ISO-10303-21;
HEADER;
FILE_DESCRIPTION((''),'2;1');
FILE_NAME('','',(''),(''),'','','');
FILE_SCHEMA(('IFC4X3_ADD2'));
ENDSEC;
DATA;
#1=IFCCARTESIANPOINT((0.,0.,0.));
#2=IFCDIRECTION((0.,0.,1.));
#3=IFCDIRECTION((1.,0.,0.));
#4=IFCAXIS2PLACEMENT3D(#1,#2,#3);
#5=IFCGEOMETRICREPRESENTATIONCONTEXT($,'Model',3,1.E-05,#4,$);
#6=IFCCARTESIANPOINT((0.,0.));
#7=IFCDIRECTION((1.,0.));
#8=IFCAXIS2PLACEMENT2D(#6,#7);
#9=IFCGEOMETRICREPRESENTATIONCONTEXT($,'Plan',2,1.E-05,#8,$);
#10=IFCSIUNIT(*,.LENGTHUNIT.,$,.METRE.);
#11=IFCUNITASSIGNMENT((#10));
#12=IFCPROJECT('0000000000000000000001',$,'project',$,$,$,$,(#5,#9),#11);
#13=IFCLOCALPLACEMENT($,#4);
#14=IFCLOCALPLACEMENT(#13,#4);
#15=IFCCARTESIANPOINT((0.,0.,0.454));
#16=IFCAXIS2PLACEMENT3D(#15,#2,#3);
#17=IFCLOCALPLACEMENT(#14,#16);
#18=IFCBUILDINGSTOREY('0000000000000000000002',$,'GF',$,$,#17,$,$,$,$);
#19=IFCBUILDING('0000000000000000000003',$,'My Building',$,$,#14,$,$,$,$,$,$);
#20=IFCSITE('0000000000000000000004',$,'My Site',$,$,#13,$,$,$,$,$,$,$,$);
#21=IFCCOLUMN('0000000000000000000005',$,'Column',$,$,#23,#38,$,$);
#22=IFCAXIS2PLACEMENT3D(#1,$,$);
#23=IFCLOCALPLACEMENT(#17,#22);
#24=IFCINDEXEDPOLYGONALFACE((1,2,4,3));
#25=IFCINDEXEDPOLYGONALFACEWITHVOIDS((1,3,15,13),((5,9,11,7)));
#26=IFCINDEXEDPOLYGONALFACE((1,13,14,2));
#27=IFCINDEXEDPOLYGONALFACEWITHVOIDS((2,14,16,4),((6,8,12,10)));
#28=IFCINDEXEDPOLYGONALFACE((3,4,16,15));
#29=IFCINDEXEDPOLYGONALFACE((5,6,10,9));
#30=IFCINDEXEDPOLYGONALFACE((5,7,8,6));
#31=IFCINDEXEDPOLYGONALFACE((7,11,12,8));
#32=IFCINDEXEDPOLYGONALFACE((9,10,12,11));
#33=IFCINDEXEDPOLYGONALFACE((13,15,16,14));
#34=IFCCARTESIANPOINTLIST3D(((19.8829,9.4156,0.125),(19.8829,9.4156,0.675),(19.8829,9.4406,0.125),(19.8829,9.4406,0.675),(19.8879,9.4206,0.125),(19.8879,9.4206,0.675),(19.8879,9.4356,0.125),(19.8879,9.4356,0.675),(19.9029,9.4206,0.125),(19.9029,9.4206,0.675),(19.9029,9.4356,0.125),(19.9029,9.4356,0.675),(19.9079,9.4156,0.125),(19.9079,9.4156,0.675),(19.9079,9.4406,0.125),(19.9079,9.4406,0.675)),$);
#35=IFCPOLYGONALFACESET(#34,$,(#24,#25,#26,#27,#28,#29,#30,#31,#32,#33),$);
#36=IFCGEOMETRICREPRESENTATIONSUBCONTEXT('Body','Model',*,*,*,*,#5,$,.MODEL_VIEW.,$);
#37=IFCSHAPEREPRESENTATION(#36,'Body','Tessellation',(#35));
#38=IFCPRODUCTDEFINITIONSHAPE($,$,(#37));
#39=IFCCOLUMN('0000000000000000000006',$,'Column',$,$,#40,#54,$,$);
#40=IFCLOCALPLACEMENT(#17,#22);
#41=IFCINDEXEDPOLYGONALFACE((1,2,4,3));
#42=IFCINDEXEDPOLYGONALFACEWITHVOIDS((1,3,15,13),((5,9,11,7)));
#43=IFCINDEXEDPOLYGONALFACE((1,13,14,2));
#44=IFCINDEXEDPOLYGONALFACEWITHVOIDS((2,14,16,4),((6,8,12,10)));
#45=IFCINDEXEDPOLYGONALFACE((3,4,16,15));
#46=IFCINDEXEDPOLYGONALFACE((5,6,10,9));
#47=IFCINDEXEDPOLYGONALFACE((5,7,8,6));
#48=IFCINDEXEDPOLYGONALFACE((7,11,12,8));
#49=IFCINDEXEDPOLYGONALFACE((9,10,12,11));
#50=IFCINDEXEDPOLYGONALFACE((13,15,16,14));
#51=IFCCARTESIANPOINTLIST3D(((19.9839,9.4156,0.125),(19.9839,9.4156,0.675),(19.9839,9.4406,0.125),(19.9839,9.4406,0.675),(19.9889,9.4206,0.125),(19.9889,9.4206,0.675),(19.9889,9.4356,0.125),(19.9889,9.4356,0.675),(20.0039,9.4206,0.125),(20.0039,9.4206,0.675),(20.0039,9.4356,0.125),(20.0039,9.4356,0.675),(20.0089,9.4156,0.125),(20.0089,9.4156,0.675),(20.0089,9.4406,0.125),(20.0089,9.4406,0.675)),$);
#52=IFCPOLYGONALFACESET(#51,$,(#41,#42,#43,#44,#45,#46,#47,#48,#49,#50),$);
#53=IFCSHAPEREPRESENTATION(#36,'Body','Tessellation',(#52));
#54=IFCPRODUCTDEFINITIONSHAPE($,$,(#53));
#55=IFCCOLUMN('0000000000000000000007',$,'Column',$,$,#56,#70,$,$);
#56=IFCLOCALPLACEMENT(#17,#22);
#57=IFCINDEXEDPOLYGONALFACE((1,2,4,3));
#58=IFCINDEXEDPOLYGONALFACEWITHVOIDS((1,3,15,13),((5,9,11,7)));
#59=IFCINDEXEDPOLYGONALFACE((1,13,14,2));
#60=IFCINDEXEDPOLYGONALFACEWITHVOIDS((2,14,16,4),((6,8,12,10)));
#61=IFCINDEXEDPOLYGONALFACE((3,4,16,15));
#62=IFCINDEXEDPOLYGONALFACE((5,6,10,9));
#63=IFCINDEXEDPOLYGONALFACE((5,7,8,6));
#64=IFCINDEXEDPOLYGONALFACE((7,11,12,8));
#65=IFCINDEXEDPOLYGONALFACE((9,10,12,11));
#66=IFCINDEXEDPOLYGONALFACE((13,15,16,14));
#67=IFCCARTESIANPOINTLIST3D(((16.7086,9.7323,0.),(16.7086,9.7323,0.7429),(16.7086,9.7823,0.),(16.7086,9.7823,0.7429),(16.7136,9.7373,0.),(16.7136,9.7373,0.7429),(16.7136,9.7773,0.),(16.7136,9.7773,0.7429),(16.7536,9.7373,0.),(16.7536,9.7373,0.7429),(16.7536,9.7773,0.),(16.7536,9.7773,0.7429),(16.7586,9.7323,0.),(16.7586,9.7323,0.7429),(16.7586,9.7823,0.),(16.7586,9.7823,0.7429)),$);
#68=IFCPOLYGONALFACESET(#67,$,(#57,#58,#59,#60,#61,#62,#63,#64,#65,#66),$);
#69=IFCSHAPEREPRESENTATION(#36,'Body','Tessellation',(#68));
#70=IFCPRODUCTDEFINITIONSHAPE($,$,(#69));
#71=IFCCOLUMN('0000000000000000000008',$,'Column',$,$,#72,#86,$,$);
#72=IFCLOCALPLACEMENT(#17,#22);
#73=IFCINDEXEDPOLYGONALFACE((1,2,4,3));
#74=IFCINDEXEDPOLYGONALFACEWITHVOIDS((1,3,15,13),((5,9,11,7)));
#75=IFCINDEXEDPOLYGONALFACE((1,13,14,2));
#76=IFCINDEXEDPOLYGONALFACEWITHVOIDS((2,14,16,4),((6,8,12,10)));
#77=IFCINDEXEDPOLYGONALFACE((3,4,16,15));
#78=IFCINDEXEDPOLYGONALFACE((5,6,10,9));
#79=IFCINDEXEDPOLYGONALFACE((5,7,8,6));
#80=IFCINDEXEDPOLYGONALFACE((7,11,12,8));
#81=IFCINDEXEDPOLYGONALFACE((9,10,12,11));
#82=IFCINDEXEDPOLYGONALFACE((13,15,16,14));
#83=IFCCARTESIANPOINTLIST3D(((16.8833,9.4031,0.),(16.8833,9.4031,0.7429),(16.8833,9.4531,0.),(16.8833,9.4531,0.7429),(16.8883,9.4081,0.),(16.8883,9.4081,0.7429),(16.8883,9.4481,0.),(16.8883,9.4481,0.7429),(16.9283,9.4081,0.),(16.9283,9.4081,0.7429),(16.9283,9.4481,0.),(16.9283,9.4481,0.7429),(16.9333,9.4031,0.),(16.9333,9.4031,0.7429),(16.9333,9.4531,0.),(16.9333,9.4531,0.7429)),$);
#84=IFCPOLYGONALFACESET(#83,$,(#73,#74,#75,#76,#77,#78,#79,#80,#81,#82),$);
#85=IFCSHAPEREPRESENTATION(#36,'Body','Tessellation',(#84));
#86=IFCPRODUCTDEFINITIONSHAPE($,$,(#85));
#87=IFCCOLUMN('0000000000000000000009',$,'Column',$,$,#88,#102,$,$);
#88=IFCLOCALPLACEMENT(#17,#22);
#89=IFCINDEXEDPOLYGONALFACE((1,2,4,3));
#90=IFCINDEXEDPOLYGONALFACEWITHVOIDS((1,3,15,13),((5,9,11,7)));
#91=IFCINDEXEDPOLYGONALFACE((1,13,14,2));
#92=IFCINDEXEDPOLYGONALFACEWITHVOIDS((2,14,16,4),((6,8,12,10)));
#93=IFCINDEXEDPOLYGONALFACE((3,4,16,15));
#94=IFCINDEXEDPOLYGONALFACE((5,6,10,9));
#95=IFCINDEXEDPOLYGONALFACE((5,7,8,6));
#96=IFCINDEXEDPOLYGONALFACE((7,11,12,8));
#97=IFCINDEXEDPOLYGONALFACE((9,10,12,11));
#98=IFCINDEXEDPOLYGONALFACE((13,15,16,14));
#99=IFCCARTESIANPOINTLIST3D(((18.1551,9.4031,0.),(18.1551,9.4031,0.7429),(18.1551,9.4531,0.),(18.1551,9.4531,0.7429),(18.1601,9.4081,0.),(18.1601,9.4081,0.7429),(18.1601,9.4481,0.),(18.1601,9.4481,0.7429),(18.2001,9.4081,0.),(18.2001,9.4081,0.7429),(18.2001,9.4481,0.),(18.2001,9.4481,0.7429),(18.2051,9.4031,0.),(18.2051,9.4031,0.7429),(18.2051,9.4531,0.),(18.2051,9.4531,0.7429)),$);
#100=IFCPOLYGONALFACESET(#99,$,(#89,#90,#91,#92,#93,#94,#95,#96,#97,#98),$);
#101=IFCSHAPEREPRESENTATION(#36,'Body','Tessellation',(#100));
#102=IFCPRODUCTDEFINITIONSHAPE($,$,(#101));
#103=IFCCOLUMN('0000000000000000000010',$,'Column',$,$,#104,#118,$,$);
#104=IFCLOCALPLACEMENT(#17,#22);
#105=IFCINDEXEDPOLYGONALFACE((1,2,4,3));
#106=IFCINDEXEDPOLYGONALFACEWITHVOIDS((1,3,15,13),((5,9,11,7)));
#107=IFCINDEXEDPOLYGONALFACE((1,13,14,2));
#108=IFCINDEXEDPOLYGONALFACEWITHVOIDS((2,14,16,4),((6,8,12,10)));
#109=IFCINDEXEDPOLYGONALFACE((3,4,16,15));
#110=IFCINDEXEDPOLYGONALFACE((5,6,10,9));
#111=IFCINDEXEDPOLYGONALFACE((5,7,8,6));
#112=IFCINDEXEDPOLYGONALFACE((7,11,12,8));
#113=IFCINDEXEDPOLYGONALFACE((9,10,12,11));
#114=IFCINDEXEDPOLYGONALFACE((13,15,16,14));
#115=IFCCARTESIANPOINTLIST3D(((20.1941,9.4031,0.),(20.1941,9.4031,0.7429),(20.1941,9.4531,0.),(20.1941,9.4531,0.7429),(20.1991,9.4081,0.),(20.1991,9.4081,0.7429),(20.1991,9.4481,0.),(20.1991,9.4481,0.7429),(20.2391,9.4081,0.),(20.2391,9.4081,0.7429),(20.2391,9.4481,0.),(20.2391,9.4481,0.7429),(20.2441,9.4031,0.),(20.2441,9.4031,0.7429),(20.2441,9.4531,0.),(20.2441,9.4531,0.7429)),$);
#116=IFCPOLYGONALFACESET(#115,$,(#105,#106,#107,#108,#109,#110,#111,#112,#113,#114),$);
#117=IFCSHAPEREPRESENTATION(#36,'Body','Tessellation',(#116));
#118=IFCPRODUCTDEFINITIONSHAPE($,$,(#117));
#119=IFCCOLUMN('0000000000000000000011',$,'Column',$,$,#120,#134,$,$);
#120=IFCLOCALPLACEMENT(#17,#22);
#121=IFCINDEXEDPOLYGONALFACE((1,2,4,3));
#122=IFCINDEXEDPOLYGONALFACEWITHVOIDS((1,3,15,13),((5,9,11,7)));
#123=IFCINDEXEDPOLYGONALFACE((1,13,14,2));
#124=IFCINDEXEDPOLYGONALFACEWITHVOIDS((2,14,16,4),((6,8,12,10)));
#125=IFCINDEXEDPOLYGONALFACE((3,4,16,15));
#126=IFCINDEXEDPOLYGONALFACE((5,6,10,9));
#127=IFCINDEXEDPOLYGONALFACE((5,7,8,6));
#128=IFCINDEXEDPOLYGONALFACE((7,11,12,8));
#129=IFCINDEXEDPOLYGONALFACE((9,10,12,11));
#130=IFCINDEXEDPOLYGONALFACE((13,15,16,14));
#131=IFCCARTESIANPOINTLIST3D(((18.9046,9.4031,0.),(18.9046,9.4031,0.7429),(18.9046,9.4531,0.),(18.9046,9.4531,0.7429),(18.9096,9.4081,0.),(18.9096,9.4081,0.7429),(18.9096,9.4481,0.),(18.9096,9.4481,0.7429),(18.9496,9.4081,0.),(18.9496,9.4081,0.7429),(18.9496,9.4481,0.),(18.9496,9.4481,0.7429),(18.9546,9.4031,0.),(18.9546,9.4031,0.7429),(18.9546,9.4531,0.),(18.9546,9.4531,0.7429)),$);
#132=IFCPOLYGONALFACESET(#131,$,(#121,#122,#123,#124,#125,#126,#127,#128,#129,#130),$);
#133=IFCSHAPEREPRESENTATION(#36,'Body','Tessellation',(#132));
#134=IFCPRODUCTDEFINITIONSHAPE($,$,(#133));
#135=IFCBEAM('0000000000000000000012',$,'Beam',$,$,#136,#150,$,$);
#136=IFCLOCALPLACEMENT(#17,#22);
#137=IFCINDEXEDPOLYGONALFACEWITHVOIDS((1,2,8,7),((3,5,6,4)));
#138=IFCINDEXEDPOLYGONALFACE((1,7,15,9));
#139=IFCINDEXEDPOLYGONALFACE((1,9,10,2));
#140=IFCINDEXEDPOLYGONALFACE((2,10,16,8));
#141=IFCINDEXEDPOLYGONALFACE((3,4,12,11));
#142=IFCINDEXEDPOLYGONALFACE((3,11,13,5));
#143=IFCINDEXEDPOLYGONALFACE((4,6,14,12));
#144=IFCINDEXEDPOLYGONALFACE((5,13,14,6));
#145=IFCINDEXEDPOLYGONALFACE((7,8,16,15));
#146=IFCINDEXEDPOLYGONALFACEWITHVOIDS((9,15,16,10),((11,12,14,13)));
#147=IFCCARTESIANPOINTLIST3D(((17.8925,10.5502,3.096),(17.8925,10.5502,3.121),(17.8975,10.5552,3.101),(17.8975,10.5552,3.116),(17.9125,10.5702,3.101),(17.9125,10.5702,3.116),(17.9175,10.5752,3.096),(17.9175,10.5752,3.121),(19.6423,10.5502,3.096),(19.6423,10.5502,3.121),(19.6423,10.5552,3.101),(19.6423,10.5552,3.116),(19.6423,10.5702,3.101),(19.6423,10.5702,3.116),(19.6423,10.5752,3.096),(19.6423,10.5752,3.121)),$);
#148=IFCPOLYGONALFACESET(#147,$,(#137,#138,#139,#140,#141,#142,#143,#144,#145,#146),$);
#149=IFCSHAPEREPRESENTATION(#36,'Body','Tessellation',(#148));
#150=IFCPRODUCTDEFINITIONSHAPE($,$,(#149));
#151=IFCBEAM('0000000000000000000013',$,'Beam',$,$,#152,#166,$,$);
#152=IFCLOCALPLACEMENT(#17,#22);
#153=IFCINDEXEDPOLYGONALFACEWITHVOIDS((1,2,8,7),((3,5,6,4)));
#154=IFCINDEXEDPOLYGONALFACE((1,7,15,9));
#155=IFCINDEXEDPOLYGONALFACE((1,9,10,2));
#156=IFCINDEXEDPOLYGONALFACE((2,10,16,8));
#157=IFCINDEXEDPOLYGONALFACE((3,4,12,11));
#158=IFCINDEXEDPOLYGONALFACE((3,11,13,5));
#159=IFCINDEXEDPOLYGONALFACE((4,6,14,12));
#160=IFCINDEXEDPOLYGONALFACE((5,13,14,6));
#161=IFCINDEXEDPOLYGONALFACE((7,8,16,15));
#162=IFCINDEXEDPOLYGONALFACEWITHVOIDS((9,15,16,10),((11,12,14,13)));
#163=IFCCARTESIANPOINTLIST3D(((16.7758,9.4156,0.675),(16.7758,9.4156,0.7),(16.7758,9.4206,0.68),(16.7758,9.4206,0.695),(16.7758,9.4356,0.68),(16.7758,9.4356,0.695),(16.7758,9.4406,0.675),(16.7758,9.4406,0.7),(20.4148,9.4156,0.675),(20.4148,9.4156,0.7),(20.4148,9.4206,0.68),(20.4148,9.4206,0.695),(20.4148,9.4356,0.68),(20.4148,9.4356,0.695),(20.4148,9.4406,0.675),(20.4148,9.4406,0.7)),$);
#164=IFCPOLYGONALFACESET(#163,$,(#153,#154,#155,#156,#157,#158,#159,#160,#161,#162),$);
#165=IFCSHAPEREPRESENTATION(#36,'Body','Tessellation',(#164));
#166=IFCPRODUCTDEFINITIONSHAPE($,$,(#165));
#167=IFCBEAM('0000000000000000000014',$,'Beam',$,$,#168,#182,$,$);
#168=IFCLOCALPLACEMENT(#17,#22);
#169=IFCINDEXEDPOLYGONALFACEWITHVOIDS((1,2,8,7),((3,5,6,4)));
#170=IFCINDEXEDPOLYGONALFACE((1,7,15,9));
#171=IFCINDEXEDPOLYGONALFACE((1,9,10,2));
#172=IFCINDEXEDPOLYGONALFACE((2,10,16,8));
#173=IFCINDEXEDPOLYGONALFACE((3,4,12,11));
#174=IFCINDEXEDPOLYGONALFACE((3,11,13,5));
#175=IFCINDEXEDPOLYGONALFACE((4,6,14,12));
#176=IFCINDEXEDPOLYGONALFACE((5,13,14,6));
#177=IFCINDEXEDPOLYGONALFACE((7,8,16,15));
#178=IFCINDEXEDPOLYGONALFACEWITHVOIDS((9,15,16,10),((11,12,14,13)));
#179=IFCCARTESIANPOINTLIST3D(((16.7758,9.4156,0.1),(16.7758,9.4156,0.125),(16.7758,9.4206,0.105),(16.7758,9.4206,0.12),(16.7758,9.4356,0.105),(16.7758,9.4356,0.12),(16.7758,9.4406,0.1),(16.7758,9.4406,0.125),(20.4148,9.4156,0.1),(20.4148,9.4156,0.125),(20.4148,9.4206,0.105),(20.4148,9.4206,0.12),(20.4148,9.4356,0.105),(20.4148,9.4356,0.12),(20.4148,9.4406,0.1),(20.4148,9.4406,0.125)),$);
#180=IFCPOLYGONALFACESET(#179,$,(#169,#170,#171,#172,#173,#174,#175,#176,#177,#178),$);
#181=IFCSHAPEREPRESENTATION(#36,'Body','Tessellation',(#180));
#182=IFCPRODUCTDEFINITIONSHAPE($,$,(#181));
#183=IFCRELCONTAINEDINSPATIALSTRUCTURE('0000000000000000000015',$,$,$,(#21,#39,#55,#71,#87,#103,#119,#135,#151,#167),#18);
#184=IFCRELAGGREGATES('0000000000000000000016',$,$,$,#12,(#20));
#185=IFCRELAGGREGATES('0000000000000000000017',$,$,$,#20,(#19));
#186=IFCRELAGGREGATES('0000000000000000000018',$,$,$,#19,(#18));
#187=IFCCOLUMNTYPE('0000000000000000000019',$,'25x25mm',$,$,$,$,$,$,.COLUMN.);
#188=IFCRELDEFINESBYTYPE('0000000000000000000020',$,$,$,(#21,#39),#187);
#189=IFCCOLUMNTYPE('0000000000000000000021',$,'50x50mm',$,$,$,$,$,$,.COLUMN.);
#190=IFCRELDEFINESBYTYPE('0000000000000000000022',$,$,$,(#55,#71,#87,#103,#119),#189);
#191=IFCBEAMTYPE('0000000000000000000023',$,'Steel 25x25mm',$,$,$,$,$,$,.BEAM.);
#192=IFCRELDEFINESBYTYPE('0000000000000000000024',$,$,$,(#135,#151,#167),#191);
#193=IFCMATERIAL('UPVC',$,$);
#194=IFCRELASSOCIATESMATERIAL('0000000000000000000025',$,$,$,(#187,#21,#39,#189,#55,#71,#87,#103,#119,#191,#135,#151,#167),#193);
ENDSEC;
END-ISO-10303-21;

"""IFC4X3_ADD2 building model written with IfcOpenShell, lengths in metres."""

from ifc_helpers import new_model, si_unit, frame, origin_with_axes, origin_2d_with_axis, place, context, subcontext, project, spatial, hollow_rectangle, extrude, clip, halfspace, material, material_profile, profile_set, profile_usage, type_object, element, save


model = new_model("IFC4X3_ADD2")

# Units and contexts
model_context = context("Model", 3, precision=1e-05, world=origin_with_axes())
plan_context = context("Plan", 2, precision=1e-05, world=origin_2d_with_axis())
body_context = subcontext(model_context, "Body", "Model", "MODEL_VIEW")
ifc_project = project(units=[si_unit("LENGTHUNIT", "METRE")], contexts=[model_context, plan_context])

# Site, building, storey
site_placement = place(None, origin_with_axes())
site = spatial("IfcSite", under=ifc_project, at=site_placement, Name="My Site")
building_placement = place(site_placement, origin_with_axes())
building = spatial("IfcBuilding", under=site, at=building_placement, Name="My Building")
storey_placement = place(building_placement, frame((0.0, 0.0, 0.454), z_axis=(0.0, 0.0, 1.0), x_axis=(1.0, 0.0, 0.0)))
storey = spatial("IfcBuildingStorey", under=building, at=storey_placement, Name="GF")

# Columns
ifc_material_1 = material(Name="UPVC")
ifc_material_profile_1 = material_profile(ifc_material_1, hollow_rectangle(XDim=0.025, YDim=0.025, WallThickness=0.005))
ifc_profile_set_1 = profile_set([ifc_material_profile_1])
column_type_1 = type_object("IfcColumnType", Name="25x25mm", PredefinedType="COLUMN", material=ifc_profile_set_1)
ifc_profile_usage_1 = profile_usage(ifc_profile_set_1)
column_1_placement = place(storey_placement, frame((19.8954, 9.4281, 0.125), z_axis=(0.0, 0.0, 1.0), x_axis=(0.0, -1.0, 0.0)))
element("IfcColumn", 1, at=column_1_placement, inside=storey, type_object=column_type_1, material=ifc_profile_usage_1, Name="Column", context=body_context, shape_type="SweptSolid", body=[
    extrude(hollow_rectangle(XDim=0.025, YDim=0.025, WallThickness=0.005), origin_with_axes(), (0.0, 0.0, 1.0), 0.55),
])
ifc_profile_usage_2 = profile_usage(ifc_profile_set_1)
column_2_placement = place(storey_placement, frame((19.9964, 9.4281, 0.125), z_axis=(0.0, 0.0, 1.0), x_axis=(0.0, -1.0, 0.0)))
element("IfcColumn", 2, at=column_2_placement, inside=storey, type_object=column_type_1, material=ifc_profile_usage_2, Name="Column", context=body_context, shape_type="SweptSolid", body=[
    extrude(hollow_rectangle(XDim=0.025, YDim=0.025, WallThickness=0.005), origin_with_axes(), (0.0, 0.0, 1.0), 0.55),
])
ifc_material_profile_2 = material_profile(ifc_material_1, hollow_rectangle(XDim=0.05, YDim=0.05, WallThickness=0.005))
ifc_profile_set_2 = profile_set([ifc_material_profile_2])
ifc_profile_usage_3 = profile_usage(ifc_profile_set_2)
column_type_2 = type_object("IfcColumnType", Name="50x50mm", PredefinedType="COLUMN", material=ifc_profile_set_2)
column_3_placement = place(storey_placement, frame((16.7336, 9.7573, 0.0), z_axis=(0.0, 0.0, 1.0), x_axis=(0.0, -1.0, 0.0)))
element("IfcColumn", 3, at=column_3_placement, inside=storey, type_object=column_type_2, material=ifc_profile_usage_3, Name="Column", context=body_context, shape_type="SweptSolid", body=[
    extrude(hollow_rectangle(XDim=0.05, YDim=0.05, WallThickness=0.005), origin_with_axes(), (0.0, 0.0, 1.0), 0.7429),
])
ifc_profile_usage_4 = profile_usage(ifc_profile_set_2)
column_4_placement = place(storey_placement, frame((16.9083, 9.4281, 0.0), z_axis=(0.0, 0.0, 1.0), x_axis=(1.0, 0.0, 0.0)))
element("IfcColumn", 4, at=column_4_placement, inside=storey, type_object=column_type_2, material=ifc_profile_usage_4, Name="Column", context=body_context, shape_type="SweptSolid", body=[
    extrude(hollow_rectangle(XDim=0.05, YDim=0.05, WallThickness=0.005), origin_with_axes(), (0.0, 0.0, 1.0), 0.7429),
])
ifc_profile_usage_5 = profile_usage(ifc_profile_set_2)
column_5_placement = place(storey_placement, frame((18.1801, 9.4281, 0.0), z_axis=(0.0, 0.0, 1.0), x_axis=(1.0, 0.0, 0.0)))
element("IfcColumn", 5, at=column_5_placement, inside=storey, type_object=column_type_2, material=ifc_profile_usage_5, Name="Column", context=body_context, shape_type="SweptSolid", body=[
    extrude(hollow_rectangle(XDim=0.05, YDim=0.05, WallThickness=0.005), origin_with_axes(), (0.0, 0.0, 1.0), 0.7429),
])
ifc_profile_usage_6 = profile_usage(ifc_profile_set_2)
column_6_placement = place(storey_placement, frame((20.2191, 9.4281, 0.0), z_axis=(0.0, 0.0, 1.0), x_axis=(1.0, 0.0, 0.0)))
element("IfcColumn", 6, at=column_6_placement, inside=storey, type_object=column_type_2, material=ifc_profile_usage_6, Name="Column", context=body_context, shape_type="SweptSolid", body=[
    extrude(hollow_rectangle(XDim=0.05, YDim=0.05, WallThickness=0.005), origin_with_axes(), (0.0, 0.0, 1.0), 0.7429),
])
ifc_profile_usage_7 = profile_usage(ifc_profile_set_2)
column_7_placement = place(storey_placement, frame((18.9296, 9.4281, 0.0), z_axis=(0.0, 0.0, 1.0), x_axis=(1.0, 0.0, 0.0)))
element("IfcColumn", 7, at=column_7_placement, inside=storey, type_object=column_type_2, material=ifc_profile_usage_7, Name="Column", context=body_context, shape_type="SweptSolid", body=[
    extrude(hollow_rectangle(XDim=0.05, YDim=0.05, WallThickness=0.005), origin_with_axes(), (0.0, 0.0, 1.0), 0.7429),
])

# Beams
ifc_material_profile_3 = material_profile(ifc_material_1, hollow_rectangle(XDim=0.025, YDim=0.025, WallThickness=0.005))
ifc_profile_set_3 = profile_set([ifc_material_profile_3])
ifc_profile_usage_8 = profile_usage(ifc_profile_set_3)
beam_type_1 = type_object("IfcBeamType", Name="Steel 25x25mm", PredefinedType="BEAM", material=ifc_profile_set_3)
beam_1_placement = place(storey_placement, frame((17.8925, 10.5627, 3.1085), z_axis=(1.0, 0.0, 0.0), x_axis=(0.0, 1.0, 0.0)))
element("IfcBeam", 8, at=beam_1_placement, inside=storey, type_object=beam_type_1, material=ifc_profile_usage_8, Name="Beam", context=body_context, shape_type="Clipping", body=[
    clip(extrude(hollow_rectangle(XDim=0.025, YDim=0.025, WallThickness=0.005), origin_with_axes(), (0.0, 0.0, 1.0), 1.7497), halfspace(frame((-0.0125, -3.5625, 0.0), z_axis=(0.707134, 0.0, -0.70708), x_axis=(0.0, -1.0, 0.0)), False)),
])
ifc_profile_usage_9 = profile_usage(ifc_profile_set_3)
beam_2_placement = place(storey_placement, frame((16.7758, 9.4281, 0.6875), z_axis=(1.0, 0.0, 0.0), x_axis=(0.0, 1.0, 0.0)))
element("IfcBeam", 9, at=beam_2_placement, inside=storey, type_object=beam_type_1, material=ifc_profile_usage_9, Name="Beam", context=body_context, shape_type="SweptSolid", body=[
    extrude(hollow_rectangle(XDim=0.025, YDim=0.025, WallThickness=0.005), origin_with_axes(), (0.0, 0.0, 1.0), 3.6389),
])
ifc_profile_usage_10 = profile_usage(ifc_profile_set_3)
beam_3_placement = place(storey_placement, frame((16.7758, 9.4281, 0.1125), z_axis=(1.0, 0.0, 0.0), x_axis=(0.0, 1.0, 0.0)))
element("IfcBeam", 10, at=beam_3_placement, inside=storey, type_object=beam_type_1, material=ifc_profile_usage_10, Name="Beam", context=body_context, shape_type="SweptSolid", body=[
    extrude(hollow_rectangle(XDim=0.025, YDim=0.025, WallThickness=0.005), origin_with_axes(), (0.0, 0.0, 1.0), 3.6389),
])

save(model, "model.ifc")
